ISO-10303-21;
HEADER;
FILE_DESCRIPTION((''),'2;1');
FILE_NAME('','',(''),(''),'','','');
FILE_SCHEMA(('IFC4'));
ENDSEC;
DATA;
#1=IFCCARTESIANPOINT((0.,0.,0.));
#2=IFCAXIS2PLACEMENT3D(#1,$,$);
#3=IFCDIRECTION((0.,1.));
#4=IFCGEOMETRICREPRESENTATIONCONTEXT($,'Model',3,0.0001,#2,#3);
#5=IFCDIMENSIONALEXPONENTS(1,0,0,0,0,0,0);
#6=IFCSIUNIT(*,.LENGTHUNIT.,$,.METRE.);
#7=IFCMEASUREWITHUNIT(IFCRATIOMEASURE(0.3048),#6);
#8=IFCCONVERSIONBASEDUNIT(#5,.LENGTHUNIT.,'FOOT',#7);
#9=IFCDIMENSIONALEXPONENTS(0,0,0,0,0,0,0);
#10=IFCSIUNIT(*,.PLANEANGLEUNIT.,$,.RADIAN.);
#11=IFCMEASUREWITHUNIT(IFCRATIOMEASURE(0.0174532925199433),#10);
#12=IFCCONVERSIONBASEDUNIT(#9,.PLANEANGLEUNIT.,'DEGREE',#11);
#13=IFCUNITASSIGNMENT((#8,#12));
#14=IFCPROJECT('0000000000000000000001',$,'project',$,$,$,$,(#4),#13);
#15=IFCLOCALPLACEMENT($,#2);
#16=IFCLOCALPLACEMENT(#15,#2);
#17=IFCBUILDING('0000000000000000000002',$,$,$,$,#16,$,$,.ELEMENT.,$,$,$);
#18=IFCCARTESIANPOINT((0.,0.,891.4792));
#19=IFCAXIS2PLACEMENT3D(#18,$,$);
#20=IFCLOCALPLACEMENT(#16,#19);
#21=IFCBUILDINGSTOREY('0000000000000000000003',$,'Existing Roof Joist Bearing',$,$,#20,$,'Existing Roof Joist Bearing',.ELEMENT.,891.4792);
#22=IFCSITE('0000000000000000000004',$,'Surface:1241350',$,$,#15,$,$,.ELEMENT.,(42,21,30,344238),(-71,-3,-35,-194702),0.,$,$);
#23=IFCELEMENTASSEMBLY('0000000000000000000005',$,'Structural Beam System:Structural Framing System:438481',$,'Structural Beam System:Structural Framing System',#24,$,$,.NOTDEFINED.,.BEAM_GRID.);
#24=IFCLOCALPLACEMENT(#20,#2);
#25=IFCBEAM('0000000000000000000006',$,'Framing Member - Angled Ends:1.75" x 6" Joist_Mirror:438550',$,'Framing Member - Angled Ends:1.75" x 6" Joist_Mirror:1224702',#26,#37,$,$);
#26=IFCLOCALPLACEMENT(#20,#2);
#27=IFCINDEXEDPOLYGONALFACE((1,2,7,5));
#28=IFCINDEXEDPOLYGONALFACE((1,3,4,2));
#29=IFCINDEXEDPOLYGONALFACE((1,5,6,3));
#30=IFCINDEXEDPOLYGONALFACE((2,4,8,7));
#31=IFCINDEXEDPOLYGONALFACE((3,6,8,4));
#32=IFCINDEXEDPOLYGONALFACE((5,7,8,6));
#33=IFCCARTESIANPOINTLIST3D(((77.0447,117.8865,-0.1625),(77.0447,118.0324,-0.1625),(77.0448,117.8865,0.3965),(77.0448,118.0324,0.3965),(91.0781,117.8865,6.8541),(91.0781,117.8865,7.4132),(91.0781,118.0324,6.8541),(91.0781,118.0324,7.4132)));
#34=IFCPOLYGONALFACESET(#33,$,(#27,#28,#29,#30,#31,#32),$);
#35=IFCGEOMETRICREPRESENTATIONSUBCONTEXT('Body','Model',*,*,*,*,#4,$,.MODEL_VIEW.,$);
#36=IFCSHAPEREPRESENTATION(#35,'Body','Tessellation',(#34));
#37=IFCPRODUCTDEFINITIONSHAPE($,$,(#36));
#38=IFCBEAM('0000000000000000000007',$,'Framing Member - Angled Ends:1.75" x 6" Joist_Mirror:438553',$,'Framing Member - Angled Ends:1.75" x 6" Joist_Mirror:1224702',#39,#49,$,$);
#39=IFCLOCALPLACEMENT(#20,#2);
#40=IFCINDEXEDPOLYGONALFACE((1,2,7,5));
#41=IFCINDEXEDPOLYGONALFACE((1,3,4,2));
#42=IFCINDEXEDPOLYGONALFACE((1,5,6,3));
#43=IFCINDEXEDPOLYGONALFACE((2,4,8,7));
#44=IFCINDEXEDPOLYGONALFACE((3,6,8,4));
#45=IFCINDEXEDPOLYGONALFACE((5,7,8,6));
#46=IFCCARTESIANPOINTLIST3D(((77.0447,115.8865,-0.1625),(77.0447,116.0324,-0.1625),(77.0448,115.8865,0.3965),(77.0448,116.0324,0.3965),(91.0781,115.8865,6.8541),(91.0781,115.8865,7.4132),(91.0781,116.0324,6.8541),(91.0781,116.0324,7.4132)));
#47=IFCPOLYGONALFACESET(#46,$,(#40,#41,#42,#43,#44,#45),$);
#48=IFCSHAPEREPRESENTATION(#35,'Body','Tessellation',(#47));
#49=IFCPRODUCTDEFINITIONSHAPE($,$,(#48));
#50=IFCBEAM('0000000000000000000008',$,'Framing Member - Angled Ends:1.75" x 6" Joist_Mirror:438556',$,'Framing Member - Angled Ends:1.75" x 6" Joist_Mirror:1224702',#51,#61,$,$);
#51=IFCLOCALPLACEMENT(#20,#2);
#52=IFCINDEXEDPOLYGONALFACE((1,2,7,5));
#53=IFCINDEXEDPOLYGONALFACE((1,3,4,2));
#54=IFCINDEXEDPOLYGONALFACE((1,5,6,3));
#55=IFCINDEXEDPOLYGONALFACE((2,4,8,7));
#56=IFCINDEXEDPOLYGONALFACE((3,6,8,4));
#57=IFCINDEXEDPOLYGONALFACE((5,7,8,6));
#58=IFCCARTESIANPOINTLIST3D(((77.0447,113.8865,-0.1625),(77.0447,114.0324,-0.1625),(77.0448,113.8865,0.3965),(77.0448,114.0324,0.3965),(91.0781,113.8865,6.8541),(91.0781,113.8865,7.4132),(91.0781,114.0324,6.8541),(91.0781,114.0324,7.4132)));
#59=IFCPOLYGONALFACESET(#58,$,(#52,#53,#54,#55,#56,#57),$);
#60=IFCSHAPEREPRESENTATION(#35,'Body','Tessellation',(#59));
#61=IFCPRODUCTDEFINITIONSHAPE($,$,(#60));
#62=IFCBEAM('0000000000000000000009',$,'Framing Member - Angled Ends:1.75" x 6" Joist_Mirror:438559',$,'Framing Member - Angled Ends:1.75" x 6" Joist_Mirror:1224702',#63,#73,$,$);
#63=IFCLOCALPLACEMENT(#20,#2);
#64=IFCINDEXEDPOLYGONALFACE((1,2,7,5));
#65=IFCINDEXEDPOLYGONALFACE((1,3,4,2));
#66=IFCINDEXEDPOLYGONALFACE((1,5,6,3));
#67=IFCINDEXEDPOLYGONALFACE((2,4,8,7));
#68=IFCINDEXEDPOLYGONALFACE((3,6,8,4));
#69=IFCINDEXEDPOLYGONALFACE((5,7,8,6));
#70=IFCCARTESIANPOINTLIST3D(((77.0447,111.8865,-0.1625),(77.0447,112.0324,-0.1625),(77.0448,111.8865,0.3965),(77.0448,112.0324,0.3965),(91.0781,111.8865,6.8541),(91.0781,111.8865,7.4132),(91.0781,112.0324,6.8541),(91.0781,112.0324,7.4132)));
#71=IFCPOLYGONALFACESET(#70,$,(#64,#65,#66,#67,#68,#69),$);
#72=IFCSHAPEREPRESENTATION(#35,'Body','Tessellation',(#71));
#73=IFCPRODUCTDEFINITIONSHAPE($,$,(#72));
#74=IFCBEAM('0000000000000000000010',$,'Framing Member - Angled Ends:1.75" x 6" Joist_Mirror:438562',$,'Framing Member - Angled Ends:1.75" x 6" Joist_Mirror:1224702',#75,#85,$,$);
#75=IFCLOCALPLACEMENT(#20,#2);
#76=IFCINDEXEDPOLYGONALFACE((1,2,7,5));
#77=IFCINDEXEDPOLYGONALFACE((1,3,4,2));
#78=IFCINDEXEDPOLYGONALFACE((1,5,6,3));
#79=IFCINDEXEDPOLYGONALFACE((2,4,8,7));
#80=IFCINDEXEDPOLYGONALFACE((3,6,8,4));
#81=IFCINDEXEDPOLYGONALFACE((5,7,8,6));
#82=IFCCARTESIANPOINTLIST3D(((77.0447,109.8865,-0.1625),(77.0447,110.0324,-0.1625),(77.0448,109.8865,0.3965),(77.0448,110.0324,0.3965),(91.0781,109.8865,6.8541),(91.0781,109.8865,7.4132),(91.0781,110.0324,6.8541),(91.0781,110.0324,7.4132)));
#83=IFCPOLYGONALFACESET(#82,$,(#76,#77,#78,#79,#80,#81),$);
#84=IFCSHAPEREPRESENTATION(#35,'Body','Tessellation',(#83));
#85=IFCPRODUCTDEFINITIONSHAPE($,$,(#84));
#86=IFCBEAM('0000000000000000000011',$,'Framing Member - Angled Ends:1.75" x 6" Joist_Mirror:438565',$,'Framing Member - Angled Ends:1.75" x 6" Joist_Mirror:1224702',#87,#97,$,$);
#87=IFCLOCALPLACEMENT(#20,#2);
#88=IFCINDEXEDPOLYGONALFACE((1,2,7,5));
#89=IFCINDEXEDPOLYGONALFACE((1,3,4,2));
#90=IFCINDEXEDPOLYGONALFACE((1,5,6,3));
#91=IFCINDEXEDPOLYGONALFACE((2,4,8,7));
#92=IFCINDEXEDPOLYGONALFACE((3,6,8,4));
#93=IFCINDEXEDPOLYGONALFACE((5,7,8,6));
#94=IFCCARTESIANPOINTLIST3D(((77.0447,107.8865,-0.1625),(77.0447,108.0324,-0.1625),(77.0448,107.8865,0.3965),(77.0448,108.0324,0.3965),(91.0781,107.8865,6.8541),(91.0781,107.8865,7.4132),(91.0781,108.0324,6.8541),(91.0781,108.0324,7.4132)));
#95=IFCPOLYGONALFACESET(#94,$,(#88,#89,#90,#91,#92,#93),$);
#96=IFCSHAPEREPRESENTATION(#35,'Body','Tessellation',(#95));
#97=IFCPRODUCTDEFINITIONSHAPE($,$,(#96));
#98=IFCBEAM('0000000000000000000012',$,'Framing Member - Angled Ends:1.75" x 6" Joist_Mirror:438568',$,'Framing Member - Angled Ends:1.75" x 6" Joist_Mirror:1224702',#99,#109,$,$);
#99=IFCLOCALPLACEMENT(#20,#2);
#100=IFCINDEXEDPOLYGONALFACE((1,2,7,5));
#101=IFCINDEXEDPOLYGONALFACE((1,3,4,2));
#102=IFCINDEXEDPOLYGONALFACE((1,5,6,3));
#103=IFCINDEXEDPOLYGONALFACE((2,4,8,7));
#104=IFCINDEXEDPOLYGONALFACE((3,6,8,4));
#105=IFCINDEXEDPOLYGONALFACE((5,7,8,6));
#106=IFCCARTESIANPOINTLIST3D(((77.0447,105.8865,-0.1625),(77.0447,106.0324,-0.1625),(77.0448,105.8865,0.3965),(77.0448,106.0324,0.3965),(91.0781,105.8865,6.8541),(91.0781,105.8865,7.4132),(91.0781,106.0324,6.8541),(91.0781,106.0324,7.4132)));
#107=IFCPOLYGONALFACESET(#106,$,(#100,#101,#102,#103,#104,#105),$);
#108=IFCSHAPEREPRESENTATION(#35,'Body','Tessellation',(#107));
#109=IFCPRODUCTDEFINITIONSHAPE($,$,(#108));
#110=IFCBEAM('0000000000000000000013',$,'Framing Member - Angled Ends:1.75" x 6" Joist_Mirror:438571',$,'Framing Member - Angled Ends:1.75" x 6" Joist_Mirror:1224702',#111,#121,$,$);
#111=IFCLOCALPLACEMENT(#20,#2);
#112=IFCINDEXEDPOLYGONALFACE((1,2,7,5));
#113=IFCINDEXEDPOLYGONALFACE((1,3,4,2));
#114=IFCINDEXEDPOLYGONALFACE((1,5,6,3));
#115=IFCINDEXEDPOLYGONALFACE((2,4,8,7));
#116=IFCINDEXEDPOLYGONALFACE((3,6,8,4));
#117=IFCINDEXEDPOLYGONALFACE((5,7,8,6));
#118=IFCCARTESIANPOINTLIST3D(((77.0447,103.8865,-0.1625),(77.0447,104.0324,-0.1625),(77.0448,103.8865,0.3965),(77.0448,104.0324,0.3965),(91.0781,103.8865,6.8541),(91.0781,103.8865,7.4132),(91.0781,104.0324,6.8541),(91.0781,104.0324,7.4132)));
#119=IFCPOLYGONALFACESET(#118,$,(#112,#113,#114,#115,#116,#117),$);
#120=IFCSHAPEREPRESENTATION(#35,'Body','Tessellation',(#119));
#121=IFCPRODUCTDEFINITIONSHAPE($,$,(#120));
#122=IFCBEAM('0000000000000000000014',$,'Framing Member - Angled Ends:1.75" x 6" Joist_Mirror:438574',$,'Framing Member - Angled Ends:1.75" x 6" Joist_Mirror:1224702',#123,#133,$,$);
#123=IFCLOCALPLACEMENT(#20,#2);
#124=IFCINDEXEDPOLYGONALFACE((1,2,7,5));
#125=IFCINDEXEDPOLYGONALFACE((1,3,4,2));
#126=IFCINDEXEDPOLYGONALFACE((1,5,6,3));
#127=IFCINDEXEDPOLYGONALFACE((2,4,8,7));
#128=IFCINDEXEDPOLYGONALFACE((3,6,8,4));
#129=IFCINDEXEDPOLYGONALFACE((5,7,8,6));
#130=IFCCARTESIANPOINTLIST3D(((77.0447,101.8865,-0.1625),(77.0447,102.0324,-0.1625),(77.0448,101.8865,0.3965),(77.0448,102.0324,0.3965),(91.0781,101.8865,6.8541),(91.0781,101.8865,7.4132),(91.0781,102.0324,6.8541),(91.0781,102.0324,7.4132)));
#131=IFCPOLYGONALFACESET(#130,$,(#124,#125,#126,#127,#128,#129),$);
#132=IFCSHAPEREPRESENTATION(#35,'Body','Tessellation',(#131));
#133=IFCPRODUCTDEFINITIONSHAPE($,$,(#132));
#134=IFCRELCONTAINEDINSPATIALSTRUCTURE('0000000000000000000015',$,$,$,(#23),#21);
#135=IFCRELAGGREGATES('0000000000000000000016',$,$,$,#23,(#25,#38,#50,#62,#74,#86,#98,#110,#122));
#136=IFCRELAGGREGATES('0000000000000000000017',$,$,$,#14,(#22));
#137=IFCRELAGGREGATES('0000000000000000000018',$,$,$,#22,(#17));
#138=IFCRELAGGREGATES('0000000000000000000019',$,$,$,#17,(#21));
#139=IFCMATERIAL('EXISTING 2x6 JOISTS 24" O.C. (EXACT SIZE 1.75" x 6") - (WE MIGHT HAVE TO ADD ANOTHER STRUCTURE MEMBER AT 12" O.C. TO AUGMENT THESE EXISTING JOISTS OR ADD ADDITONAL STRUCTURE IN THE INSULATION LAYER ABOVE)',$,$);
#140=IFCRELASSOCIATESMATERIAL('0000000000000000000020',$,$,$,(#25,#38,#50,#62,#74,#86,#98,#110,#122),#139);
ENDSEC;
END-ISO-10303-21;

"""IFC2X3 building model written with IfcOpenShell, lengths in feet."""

from ifc_helpers import new_model, entity, si_unit, converted_unit, direction, frame, frame_2d, origin, place, context, subcontext, project, spatial, rectangle, extrude, clip, halfspace, material, element, aggregate, save


model = new_model("IFC2X3")

# Units and contexts
model_context = context("Model", 3, precision=0.0001, world=origin(), true_north=direction((0.0, 1.0)))
body_context = subcontext(model_context, "Body", "Model", "MODEL_VIEW")
ifc_project = project(units=[converted_unit("LENGTHUNIT", "FOOT", entity("IfcRatioMeasure", 0.3048), si_unit("LENGTHUNIT", "METRE"), dimensions=[1, 0, 0, 0, 0, 0, 0]), converted_unit("PLANEANGLEUNIT", "DEGREE", entity("IfcRatioMeasure", 0.0174532925199433), si_unit("PLANEANGLEUNIT", "RADIAN"), dimensions=[0, 0, 0, 0, 0, 0, 0])], contexts=[model_context])

# Site, building, storey
site_placement = place(None, origin())
site = spatial("IfcSite", under=ifc_project, at=site_placement, Name="Surface:1241350", CompositionType="ELEMENT", RefLatitude=(42, 21, 30, 344238), RefLongitude=(-71, -3, -35, -194702), RefElevation=0.0)
building_placement = place(site_placement, origin())
building = spatial("IfcBuilding", under=site, at=building_placement, CompositionType="ELEMENT")
storey_placement = place(building_placement, frame((0.0, 0.0, 891.4792)))
storey = spatial("IfcBuildingStorey", under=building, at=storey_placement, Name="Existing Roof Joist Bearing", LongName="Existing Roof Joist Bearing", CompositionType="ELEMENT", Elevation=891.4792)

# Element assembly, beams
ifc_material_1 = material(Name="EXISTING 2x6 JOISTS 24\" O.C. (EXACT SIZE 1.75\" x 6\") - (WE MIGHT HAVE TO ADD ANOTHER STRUCTURE MEMBER AT 12\" O.C. TO AUGMENT THESE EXISTING JOISTS OR ADD ADDITONAL STRUCTURE IN THE INSULATION LAYER ABOVE)")
assembly_1_placement = place(storey_placement, origin())
assembly_1 = element("IfcElementAssembly", 1, at=assembly_1_placement, inside=storey, Name="Structural Beam System:Structural Framing System:438481", ObjectType="Structural Beam System:Structural Framing System", AssemblyPlace="NOTDEFINED", PredefinedType="BEAM_GRID")
beam_1_placement = place(assembly_1_placement, frame((91.0781, 117.9594, 7.4132), z_axis=(-0.447214, 0.0, 0.894427), x_axis=(-0.894427, 0.0, -0.447214)))
beam_1 = element("IfcBeam", 2, at=beam_1_placement, material=ifc_material_1, Name="Framing Member - Angled Ends:1.75\" x 6\" Joist_Mirror:438550", ObjectType="Framing Member - Angled Ends:1.75\" x 6\" Joist_Mirror:1224702", context=body_context, shape_type="Clipping", body=[
    clip(clip(extrude(rectangle(XDim=0.5, YDim=0.1458, at=frame_2d((0.0, 0.0), x_axis=(1.0, 0.0))), frame((0.0, 0.0, -0.25), z_axis=(1.0, 0.0, 0.0), x_axis=(0.0, 0.0, -1.0)), (0.0, 0.0, 1.0), 15.9398), halfspace(frame((0.0, -0.0729, 0.0), z_axis=(-0.894389, 0.0, -0.447291), x_axis=(0.0, -1.0, 0.0)), False)), halfspace(frame((15.9398, -0.0729, -0.5), z_axis=(0.894389, 0.0, 0.447291), x_axis=(0.0, 1.0, 0.0)), False)),
])
beam_2_placement = place(assembly_1_placement, frame((91.0781, 115.9594, 7.4132), z_axis=(-0.447214, 0.0, 0.894427), x_axis=(-0.894427, 0.0, -0.447214)))
beam_2 = element("IfcBeam", 3, at=beam_2_placement, material=ifc_material_1, Name="Framing Member - Angled Ends:1.75\" x 6\" Joist_Mirror:438553", ObjectType="Framing Member - Angled Ends:1.75\" x 6\" Joist_Mirror:1224702", context=body_context, shape_type="Clipping", body=[
    clip(clip(extrude(rectangle(XDim=0.5, YDim=0.1458, at=frame_2d((0.0, 0.0), x_axis=(1.0, 0.0))), frame((0.0, 0.0, -0.25), z_axis=(1.0, 0.0, 0.0), x_axis=(0.0, 0.0, -1.0)), (0.0, 0.0, 1.0), 15.9398), halfspace(frame((0.0, -0.0729, 0.0), z_axis=(-0.894389, 0.0, -0.447291), x_axis=(0.0, -1.0, 0.0)), False)), halfspace(frame((15.9398, -0.0729, -0.5), z_axis=(0.894389, 0.0, 0.447291), x_axis=(0.0, 1.0, 0.0)), False)),
])
beam_3_placement = place(assembly_1_placement, frame((91.0781, 113.9594, 7.4132), z_axis=(-0.447214, 0.0, 0.894427), x_axis=(-0.894427, 0.0, -0.447214)))
beam_3 = element("IfcBeam", 4, at=beam_3_placement, material=ifc_material_1, Name="Framing Member - Angled Ends:1.75\" x 6\" Joist_Mirror:438556", ObjectType="Framing Member - Angled Ends:1.75\" x 6\" Joist_Mirror:1224702", context=body_context, shape_type="Clipping", body=[
    clip(clip(extrude(rectangle(XDim=0.5, YDim=0.1458, at=frame_2d((0.0, 0.0), x_axis=(1.0, 0.0))), frame((0.0, 0.0, -0.25), z_axis=(1.0, 0.0, 0.0), x_axis=(0.0, 0.0, -1.0)), (0.0, 0.0, 1.0), 15.9398), halfspace(frame((15.9398, -0.0729, -0.5), z_axis=(0.894389, 0.0, 0.447291), x_axis=(0.0, 1.0, 0.0)), False)), halfspace(frame((0.0, -0.0729, 0.0), z_axis=(-0.894389, 0.0, -0.447291), x_axis=(0.0, -1.0, 0.0)), False)),
])
beam_4_placement = place(assembly_1_placement, frame((91.0781, 111.9594, 7.4132), z_axis=(-0.447214, 0.0, 0.894427), x_axis=(-0.894427, 0.0, -0.447214)))
beam_4 = element("IfcBeam", 5, at=beam_4_placement, material=ifc_material_1, Name="Framing Member - Angled Ends:1.75\" x 6\" Joist_Mirror:438559", ObjectType="Framing Member - Angled Ends:1.75\" x 6\" Joist_Mirror:1224702", context=body_context, shape_type="Clipping", body=[
    clip(clip(extrude(rectangle(XDim=0.5, YDim=0.1458, at=frame_2d((0.0, 0.0), x_axis=(1.0, 0.0))), frame((0.0, 0.0, -0.25), z_axis=(1.0, 0.0, 0.0), x_axis=(0.0, 0.0, -1.0)), (0.0, 0.0, 1.0), 15.9398), halfspace(frame((0.0, -0.0729, 0.0), z_axis=(-0.894389, 0.0, -0.447291), x_axis=(0.0, -1.0, 0.0)), False)), halfspace(frame((15.9398, -0.0729, -0.5), z_axis=(0.894389, 0.0, 0.447291), x_axis=(0.0, 1.0, 0.0)), False)),
])
beam_5_placement = place(assembly_1_placement, frame((91.0781, 109.9594, 7.4132), z_axis=(-0.447214, 0.0, 0.894427), x_axis=(-0.894427, 0.0, -0.447214)))
beam_5 = element("IfcBeam", 6, at=beam_5_placement, material=ifc_material_1, Name="Framing Member - Angled Ends:1.75\" x 6\" Joist_Mirror:438562", ObjectType="Framing Member - Angled Ends:1.75\" x 6\" Joist_Mirror:1224702", context=body_context, shape_type="Clipping", body=[
    clip(clip(extrude(rectangle(XDim=0.5, YDim=0.1458, at=frame_2d((0.0, 0.0), x_axis=(1.0, 0.0))), frame((0.0, 0.0, -0.25), z_axis=(1.0, 0.0, 0.0), x_axis=(0.0, 0.0, -1.0)), (0.0, 0.0, 1.0), 15.9398), halfspace(frame((0.0, -0.0729, 0.0), z_axis=(-0.894389, 0.0, -0.447291), x_axis=(0.0, -1.0, 0.0)), False)), halfspace(frame((15.9398, -0.0729, -0.5), z_axis=(0.894389, 0.0, 0.447291), x_axis=(0.0, 1.0, 0.0)), False)),
])
beam_6_placement = place(assembly_1_placement, frame((91.0781, 107.9594, 7.4132), z_axis=(-0.447214, 0.0, 0.894427), x_axis=(-0.894427, 0.0, -0.447214)))
beam_6 = element("IfcBeam", 7, at=beam_6_placement, material=ifc_material_1, Name="Framing Member - Angled Ends:1.75\" x 6\" Joist_Mirror:438565", ObjectType="Framing Member - Angled Ends:1.75\" x 6\" Joist_Mirror:1224702", context=body_context, shape_type="Clipping", body=[
    clip(clip(extrude(rectangle(XDim=0.5, YDim=0.1458, at=frame_2d((0.0, 0.0), x_axis=(1.0, 0.0))), frame((0.0, 0.0, -0.25), z_axis=(1.0, 0.0, 0.0), x_axis=(0.0, 0.0, -1.0)), (0.0, 0.0, 1.0), 15.9398), halfspace(frame((0.0, -0.0729, 0.0), z_axis=(-0.894389, 0.0, -0.447291), x_axis=(0.0, -1.0, 0.0)), False)), halfspace(frame((15.9398, -0.0729, -0.5), z_axis=(0.894389, 0.0, 0.447291), x_axis=(0.0, 1.0, 0.0)), False)),
])
beam_7_placement = place(assembly_1_placement, frame((91.0781, 105.9594, 7.4132), z_axis=(-0.447214, 0.0, 0.894427), x_axis=(-0.894427, 0.0, -0.447214)))
beam_7 = element("IfcBeam", 8, at=beam_7_placement, material=ifc_material_1, Name="Framing Member - Angled Ends:1.75\" x 6\" Joist_Mirror:438568", ObjectType="Framing Member - Angled Ends:1.75\" x 6\" Joist_Mirror:1224702", context=body_context, shape_type="Clipping", body=[
    clip(clip(extrude(rectangle(XDim=0.5, YDim=0.1458, at=frame_2d((0.0, 0.0), x_axis=(1.0, 0.0))), frame((0.0, 0.0, -0.25), z_axis=(1.0, 0.0, 0.0), x_axis=(0.0, 0.0, -1.0)), (0.0, 0.0, 1.0), 15.9398), halfspace(frame((0.0, -0.0729, 0.0), z_axis=(-0.894389, 0.0, -0.447291), x_axis=(0.0, -1.0, 0.0)), False)), halfspace(frame((15.9398, -0.0729, -0.5), z_axis=(0.894389, 0.0, 0.447291), x_axis=(0.0, 1.0, 0.0)), False)),
])
beam_8_placement = place(assembly_1_placement, frame((91.0781, 103.9594, 7.4132), z_axis=(-0.447214, 0.0, 0.894427), x_axis=(-0.894427, 0.0, -0.447214)))
beam_8 = element("IfcBeam", 9, at=beam_8_placement, material=ifc_material_1, Name="Framing Member - Angled Ends:1.75\" x 6\" Joist_Mirror:438571", ObjectType="Framing Member - Angled Ends:1.75\" x 6\" Joist_Mirror:1224702", context=body_context, shape_type="Clipping", body=[
    clip(clip(extrude(rectangle(XDim=0.5, YDim=0.1458, at=frame_2d((0.0, 0.0), x_axis=(1.0, 0.0))), frame((0.0, 0.0, -0.25), z_axis=(1.0, 0.0, 0.0), x_axis=(0.0, 0.0, -1.0)), (0.0, 0.0, 1.0), 15.9398), halfspace(frame((0.0, -0.0729, 0.0), z_axis=(-0.894389, 0.0, -0.447291), x_axis=(0.0, -1.0, 0.0)), False)), halfspace(frame((15.9398, -0.0729, -0.5), z_axis=(0.894389, 0.0, 0.447291), x_axis=(0.0, 1.0, 0.0)), False)),
])
beam_9_placement = place(assembly_1_placement, frame((91.0781, 101.9594, 7.4132), z_axis=(-0.447214, 0.0, 0.894427), x_axis=(-0.894427, 0.0, -0.447214)))
beam_9 = element("IfcBeam", 10, at=beam_9_placement, material=ifc_material_1, Name="Framing Member - Angled Ends:1.75\" x 6\" Joist_Mirror:438574", ObjectType="Framing Member - Angled Ends:1.75\" x 6\" Joist_Mirror:1224702", context=body_context, shape_type="Clipping", body=[
    clip(clip(extrude(rectangle(XDim=0.5, YDim=0.1458, at=frame_2d((0.0, 0.0), x_axis=(1.0, 0.0))), frame((0.0, 0.0, -0.25), z_axis=(1.0, 0.0, 0.0), x_axis=(0.0, 0.0, -1.0)), (0.0, 0.0, 1.0), 15.9398), halfspace(frame((0.0, -0.0729, 0.0), z_axis=(-0.894389, 0.0, -0.447291), x_axis=(0.0, -1.0, 0.0)), False)), halfspace(frame((15.9398, -0.0729, -0.5), z_axis=(0.894389, 0.0, 0.447291), x_axis=(0.0, 1.0, 0.0)), False)),
])
aggregate(assembly_1, [beam_1, beam_2, beam_3, beam_4, beam_5, beam_6, beam_7, beam_8, beam_9])

save(model, "model.ifc")
